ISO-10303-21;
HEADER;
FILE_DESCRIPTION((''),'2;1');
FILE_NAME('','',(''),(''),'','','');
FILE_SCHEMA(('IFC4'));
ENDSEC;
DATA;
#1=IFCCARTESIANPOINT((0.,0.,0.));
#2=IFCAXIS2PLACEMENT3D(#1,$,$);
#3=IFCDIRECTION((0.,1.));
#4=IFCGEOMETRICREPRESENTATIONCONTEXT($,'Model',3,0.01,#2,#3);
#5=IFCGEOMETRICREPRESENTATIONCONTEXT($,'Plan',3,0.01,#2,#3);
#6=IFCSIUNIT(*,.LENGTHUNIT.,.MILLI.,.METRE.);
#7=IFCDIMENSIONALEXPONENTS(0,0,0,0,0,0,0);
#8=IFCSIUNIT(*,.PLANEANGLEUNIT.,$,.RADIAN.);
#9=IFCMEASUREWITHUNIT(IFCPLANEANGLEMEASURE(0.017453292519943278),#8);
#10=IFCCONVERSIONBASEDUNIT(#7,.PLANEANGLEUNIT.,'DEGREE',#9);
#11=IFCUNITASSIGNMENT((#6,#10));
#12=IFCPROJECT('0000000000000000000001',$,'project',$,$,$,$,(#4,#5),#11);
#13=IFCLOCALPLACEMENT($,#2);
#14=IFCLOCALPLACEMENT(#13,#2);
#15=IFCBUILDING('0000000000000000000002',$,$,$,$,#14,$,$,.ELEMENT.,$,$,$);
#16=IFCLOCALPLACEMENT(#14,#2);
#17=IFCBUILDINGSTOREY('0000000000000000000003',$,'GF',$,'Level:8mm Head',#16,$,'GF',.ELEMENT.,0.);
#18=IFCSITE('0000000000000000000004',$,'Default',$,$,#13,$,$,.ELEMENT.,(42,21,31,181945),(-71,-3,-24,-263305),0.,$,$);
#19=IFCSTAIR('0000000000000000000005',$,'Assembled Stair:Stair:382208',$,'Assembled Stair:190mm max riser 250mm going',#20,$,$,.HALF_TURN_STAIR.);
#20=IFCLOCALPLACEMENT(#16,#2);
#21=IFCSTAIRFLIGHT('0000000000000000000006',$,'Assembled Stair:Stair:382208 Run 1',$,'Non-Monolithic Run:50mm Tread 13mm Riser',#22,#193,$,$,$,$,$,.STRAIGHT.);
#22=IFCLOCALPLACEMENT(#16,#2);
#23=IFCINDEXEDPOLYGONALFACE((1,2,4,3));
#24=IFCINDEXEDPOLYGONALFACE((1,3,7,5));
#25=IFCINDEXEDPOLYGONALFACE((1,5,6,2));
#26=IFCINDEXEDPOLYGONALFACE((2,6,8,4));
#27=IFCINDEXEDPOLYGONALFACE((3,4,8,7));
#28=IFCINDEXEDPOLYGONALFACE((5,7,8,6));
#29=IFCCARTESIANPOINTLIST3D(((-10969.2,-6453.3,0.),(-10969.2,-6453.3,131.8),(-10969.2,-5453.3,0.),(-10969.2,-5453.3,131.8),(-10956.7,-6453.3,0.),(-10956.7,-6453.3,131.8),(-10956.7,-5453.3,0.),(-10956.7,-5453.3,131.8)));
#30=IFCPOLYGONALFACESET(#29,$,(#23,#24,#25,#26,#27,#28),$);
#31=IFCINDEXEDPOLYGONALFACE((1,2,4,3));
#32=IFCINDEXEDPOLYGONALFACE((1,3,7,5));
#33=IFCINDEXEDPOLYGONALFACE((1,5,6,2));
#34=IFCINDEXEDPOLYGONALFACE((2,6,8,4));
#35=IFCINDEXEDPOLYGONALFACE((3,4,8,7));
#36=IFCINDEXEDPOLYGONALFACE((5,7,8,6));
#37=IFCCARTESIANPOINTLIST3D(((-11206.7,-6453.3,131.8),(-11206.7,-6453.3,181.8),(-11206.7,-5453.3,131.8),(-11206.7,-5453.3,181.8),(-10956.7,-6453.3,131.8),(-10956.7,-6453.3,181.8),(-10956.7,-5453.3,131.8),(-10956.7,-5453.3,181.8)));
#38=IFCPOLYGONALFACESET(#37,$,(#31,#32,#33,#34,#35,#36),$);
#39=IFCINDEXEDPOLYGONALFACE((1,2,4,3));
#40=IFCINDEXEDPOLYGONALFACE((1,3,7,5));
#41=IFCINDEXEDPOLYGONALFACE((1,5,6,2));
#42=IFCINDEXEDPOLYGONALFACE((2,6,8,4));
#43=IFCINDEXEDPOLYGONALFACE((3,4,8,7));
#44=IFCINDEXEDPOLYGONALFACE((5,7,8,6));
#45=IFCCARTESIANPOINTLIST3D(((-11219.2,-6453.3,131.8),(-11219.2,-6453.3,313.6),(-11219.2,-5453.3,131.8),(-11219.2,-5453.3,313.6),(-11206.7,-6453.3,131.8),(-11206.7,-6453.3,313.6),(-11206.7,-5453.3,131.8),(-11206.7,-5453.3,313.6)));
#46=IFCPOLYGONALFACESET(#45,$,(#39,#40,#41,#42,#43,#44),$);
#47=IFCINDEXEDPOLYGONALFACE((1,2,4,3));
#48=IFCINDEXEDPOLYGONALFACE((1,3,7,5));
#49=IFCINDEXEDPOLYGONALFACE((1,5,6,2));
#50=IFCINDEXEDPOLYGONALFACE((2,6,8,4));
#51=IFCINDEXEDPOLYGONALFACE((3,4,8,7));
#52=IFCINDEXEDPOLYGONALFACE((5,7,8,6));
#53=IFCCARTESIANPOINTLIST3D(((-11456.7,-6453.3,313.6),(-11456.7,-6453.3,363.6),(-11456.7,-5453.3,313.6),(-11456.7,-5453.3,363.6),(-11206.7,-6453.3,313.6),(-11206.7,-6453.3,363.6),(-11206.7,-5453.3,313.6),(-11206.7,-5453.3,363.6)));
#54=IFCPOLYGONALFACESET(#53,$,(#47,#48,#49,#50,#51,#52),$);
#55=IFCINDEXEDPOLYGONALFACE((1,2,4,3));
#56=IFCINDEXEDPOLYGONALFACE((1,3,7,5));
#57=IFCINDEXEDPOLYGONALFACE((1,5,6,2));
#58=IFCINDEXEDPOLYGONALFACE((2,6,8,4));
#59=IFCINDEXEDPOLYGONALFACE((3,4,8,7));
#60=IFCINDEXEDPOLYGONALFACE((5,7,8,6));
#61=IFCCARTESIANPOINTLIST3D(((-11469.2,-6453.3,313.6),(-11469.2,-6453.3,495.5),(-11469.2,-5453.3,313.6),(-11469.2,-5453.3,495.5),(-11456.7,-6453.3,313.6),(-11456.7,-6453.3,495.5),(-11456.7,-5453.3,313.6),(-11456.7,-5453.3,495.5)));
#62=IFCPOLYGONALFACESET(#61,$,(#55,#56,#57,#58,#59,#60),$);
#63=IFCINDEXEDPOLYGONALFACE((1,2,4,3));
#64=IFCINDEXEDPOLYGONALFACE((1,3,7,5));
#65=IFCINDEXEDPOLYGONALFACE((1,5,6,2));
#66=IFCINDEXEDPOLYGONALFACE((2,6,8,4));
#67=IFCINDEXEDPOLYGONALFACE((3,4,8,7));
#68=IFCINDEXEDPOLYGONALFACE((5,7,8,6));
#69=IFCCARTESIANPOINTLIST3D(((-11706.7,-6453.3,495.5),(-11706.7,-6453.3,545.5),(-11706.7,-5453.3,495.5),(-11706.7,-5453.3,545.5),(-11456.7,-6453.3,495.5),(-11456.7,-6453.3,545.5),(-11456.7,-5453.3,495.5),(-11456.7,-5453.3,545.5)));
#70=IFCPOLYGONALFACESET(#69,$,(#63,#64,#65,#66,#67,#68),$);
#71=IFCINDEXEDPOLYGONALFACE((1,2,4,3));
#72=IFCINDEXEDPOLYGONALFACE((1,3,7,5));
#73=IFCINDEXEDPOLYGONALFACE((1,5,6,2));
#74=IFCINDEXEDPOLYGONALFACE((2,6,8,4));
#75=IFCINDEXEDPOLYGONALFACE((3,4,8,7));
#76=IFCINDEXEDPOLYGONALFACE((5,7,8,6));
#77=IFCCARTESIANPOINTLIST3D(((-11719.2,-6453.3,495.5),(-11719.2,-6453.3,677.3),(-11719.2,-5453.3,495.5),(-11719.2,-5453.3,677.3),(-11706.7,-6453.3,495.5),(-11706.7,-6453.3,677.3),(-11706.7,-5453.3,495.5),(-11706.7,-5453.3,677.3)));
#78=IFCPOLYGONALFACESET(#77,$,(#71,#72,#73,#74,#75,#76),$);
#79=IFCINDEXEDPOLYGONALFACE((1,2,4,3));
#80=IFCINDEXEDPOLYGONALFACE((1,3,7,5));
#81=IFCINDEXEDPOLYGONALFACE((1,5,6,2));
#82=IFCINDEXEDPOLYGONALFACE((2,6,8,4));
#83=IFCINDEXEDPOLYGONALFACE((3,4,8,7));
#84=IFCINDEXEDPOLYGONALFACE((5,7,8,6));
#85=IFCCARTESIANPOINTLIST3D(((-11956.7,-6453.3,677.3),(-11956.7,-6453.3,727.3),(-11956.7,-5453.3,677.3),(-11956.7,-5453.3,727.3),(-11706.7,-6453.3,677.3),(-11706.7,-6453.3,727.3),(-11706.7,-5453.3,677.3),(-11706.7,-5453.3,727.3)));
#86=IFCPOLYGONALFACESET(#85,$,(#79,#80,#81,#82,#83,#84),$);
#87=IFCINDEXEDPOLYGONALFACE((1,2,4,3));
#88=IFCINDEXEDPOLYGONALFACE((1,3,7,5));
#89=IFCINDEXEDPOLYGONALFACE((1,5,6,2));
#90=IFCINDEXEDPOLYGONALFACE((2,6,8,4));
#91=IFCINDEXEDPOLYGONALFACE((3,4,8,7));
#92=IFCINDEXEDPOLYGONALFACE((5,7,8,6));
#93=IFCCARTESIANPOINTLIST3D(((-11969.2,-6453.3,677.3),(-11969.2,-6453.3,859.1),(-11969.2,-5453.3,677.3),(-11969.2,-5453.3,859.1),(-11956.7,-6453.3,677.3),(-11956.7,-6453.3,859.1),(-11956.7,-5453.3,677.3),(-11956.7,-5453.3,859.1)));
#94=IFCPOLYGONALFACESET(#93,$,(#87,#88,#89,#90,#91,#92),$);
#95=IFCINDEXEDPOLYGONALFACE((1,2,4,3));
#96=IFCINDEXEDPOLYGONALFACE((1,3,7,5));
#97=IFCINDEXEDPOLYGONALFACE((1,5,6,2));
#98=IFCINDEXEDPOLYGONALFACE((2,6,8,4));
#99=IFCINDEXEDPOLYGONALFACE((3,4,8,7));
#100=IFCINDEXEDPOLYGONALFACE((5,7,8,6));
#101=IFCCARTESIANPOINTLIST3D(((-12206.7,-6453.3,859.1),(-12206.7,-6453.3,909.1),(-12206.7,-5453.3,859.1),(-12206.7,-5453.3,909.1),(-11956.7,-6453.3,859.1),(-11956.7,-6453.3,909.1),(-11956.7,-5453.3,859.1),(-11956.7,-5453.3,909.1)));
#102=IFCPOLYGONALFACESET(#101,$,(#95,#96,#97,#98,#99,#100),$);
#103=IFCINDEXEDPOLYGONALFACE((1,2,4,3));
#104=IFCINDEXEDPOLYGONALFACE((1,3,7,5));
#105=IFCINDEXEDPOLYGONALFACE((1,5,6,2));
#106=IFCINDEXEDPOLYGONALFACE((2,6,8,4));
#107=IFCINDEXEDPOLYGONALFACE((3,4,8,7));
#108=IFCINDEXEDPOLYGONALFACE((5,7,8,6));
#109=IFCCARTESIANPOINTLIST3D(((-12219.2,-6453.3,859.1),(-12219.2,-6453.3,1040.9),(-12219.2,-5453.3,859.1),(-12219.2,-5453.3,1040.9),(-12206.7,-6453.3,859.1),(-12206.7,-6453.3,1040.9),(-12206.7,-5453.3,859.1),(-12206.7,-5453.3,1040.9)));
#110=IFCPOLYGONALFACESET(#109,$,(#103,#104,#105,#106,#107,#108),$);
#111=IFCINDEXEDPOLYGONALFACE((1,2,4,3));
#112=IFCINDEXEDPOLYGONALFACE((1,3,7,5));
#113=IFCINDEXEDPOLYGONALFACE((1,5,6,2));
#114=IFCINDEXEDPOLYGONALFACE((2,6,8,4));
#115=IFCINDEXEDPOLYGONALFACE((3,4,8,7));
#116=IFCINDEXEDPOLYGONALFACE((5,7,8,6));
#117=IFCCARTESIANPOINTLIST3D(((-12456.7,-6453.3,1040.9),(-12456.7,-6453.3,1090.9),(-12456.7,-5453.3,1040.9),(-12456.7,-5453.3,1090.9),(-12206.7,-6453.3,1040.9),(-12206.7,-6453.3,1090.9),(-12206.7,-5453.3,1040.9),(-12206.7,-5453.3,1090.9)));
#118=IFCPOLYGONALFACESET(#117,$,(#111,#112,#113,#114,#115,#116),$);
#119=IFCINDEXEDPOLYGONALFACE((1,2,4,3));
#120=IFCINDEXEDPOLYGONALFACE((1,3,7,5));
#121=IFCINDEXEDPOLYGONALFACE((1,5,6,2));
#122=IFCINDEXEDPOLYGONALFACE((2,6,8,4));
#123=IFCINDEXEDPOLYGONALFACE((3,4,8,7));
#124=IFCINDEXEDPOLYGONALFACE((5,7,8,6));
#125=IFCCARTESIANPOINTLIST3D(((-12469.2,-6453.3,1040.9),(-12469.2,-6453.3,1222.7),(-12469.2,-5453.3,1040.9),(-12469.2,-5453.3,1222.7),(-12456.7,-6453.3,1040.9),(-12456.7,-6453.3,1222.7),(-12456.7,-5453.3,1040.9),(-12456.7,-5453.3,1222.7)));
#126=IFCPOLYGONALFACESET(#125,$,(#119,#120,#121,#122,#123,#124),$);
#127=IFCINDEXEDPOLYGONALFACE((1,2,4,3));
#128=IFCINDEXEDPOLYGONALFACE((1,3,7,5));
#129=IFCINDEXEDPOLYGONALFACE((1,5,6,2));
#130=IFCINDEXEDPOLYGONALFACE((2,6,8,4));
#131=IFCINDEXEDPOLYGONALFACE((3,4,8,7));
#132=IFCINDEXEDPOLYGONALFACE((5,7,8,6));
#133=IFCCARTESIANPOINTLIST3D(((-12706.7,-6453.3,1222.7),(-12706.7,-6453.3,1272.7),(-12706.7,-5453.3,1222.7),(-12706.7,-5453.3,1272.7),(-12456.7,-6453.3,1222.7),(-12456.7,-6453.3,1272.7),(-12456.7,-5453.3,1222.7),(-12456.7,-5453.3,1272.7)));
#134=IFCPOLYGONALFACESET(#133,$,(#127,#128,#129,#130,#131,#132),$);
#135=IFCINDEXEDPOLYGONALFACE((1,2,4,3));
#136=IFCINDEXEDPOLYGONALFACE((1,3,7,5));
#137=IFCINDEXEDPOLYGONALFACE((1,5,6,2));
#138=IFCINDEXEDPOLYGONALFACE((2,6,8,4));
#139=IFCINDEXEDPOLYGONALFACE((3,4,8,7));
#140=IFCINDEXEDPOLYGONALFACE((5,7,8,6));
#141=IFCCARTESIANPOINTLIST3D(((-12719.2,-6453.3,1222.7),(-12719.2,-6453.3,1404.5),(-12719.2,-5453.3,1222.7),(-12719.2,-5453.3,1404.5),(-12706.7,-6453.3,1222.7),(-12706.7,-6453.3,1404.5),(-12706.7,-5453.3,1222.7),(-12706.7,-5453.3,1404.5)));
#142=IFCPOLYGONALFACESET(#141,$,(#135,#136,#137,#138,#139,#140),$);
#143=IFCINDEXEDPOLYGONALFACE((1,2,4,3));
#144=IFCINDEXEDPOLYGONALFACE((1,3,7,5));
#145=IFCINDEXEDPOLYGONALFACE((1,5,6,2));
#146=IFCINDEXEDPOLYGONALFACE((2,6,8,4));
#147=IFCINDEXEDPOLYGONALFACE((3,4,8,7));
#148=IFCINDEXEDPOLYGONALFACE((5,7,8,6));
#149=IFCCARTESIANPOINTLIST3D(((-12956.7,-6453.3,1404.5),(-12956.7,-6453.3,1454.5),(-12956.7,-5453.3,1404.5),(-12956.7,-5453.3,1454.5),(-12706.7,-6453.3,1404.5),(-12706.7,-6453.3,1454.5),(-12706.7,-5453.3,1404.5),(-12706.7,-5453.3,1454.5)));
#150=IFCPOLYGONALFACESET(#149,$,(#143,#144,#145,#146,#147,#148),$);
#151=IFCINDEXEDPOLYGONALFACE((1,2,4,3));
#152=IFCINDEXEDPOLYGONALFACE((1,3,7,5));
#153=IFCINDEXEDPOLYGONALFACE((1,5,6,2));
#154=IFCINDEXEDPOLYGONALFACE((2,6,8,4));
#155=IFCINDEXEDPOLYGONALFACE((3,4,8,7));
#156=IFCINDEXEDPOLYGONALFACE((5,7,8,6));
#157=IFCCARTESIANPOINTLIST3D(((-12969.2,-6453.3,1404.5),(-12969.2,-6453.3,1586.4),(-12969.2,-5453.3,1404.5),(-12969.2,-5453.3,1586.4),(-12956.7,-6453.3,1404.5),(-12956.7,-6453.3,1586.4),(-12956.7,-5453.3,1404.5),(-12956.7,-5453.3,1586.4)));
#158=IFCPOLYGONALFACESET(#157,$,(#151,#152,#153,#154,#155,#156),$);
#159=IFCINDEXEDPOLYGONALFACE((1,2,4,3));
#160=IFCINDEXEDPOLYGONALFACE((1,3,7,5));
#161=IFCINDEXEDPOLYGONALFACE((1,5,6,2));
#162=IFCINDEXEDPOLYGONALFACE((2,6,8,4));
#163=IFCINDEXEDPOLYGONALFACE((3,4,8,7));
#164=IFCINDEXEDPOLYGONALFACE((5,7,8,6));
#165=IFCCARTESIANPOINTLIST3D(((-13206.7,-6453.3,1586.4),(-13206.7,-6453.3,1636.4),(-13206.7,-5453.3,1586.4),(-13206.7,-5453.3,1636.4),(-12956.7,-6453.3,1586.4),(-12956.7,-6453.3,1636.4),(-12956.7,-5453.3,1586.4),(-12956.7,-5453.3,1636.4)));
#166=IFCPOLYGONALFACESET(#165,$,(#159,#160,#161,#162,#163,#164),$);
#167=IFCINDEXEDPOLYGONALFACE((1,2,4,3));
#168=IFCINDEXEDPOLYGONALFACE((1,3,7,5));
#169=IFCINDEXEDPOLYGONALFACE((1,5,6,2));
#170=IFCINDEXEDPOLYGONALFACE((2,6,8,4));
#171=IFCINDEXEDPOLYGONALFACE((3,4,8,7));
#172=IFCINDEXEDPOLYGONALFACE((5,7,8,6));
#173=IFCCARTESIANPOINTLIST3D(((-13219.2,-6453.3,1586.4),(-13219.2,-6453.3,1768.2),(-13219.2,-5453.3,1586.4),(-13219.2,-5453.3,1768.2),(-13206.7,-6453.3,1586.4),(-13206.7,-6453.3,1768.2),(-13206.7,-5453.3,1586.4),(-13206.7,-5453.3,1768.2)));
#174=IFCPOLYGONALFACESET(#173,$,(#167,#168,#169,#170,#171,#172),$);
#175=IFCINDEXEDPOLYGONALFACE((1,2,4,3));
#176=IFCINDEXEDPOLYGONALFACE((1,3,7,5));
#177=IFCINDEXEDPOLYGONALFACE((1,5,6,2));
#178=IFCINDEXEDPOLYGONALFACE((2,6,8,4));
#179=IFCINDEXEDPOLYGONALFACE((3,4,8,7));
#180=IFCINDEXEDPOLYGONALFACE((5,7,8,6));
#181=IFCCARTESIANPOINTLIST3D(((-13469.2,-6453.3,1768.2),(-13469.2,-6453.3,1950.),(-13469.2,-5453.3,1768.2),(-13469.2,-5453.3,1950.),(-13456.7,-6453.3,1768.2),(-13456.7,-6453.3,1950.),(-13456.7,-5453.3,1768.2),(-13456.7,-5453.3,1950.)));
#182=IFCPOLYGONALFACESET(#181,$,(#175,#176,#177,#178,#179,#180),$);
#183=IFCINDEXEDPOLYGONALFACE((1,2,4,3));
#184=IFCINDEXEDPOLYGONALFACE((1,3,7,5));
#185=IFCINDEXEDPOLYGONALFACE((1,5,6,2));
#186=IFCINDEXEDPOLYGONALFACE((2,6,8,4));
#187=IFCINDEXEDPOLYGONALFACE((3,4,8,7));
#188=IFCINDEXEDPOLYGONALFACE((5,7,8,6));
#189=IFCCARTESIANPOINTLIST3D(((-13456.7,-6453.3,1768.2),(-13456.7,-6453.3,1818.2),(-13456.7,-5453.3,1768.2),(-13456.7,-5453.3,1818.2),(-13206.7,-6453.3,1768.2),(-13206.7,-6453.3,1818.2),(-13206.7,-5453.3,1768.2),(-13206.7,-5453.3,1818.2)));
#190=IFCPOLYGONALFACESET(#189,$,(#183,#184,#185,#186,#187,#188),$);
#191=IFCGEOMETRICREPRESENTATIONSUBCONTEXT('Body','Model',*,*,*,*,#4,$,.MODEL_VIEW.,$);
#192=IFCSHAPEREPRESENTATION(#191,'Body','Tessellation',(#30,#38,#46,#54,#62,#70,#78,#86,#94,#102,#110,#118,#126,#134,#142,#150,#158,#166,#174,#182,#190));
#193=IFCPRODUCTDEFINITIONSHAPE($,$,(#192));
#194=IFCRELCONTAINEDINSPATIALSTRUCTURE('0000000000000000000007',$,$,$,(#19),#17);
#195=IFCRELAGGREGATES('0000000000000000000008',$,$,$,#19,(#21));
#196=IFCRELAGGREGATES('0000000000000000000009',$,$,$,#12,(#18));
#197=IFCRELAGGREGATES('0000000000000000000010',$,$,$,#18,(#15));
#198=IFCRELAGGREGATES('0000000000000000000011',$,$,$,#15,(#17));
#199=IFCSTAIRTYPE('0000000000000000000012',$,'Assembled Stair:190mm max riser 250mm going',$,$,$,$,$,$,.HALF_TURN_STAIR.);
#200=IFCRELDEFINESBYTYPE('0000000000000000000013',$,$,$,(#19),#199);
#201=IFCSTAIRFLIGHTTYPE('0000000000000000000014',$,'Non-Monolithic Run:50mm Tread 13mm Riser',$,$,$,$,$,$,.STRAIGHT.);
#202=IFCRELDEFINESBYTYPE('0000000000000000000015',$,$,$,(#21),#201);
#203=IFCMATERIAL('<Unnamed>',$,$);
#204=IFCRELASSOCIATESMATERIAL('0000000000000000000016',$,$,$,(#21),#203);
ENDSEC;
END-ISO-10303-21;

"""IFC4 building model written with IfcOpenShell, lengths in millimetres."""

from ifc_helpers import new_model, entity, si_unit, converted_unit, direction, frame, origin, place, context, subcontext, project, spatial, indexed_curve, outline, extrude, material, type_object, element, aggregate, save


model = new_model("IFC4")

# Units and contexts
model_context = context("Model", 3, precision=0.01, world=origin(), true_north=direction((0.0, 1.0)))
plan_context = context("Plan", 3, precision=0.01, world=origin(), true_north=direction((0.0, 1.0)))
body_context = subcontext(model_context, "Body", "Model", "MODEL_VIEW")
ifc_project = project(units=[si_unit("LENGTHUNIT", "METRE", prefix="MILLI"), converted_unit("PLANEANGLEUNIT", "DEGREE", entity("IfcPlaneAngleMeasure", 0.017453292519943278), si_unit("PLANEANGLEUNIT", "RADIAN"), dimensions=[0, 0, 0, 0, 0, 0, 0])], contexts=[model_context, plan_context])

# Site, building, storey
site_placement = place(None, origin())
site = spatial("IfcSite", under=ifc_project, at=site_placement, Name="Default", CompositionType="ELEMENT", RefLatitude=(42, 21, 31, 181945), RefLongitude=(-71, -3, -24, -263305), RefElevation=0.0)
building_placement = place(site_placement, origin())
building = spatial("IfcBuilding", under=site, at=building_placement, CompositionType="ELEMENT")
storey_placement = place(building_placement, origin())
storey = spatial("IfcBuildingStorey", under=building, at=storey_placement, Name="GF", ObjectType="Level:8mm Head", LongName="GF", CompositionType="ELEMENT", Elevation=0.0)

# Stair
stair_type = type_object("IfcStairType", Name="Assembled Stair:190mm max riser 250mm going", PredefinedType="HALF_TURN_STAIR")
stair_placement = place(storey_placement, origin())
stair = element("IfcStair", 1, at=stair_placement, inside=storey, type_object=stair_type, Name="Assembled Stair:Stair:382208", ObjectType="Assembled Stair:190mm max riser 250mm going", PredefinedType="HALF_TURN_STAIR")
ifc_material_1 = material(Name="<Unnamed>")

# Stair flight
stair_flight_type = type_object("IfcStairFlightType", Name="Non-Monolithic Run:50mm Tread 13mm Riser", PredefinedType="STRAIGHT")
stair_flight_1_placement = place(stair_placement, origin())
stair_flight_1 = element("IfcStairFlight", 2, at=stair_flight_1_placement, type_object=stair_flight_type, material=ifc_material_1, Name="Assembled Stair:Stair:382208 Run 1", ObjectType="Non-Monolithic Run:50mm Tread 13mm Riser", PredefinedType="STRAIGHT", context=body_context, shape_type="SweptSolid", body=[
    extrude(outline(indexed_curve([(-500.0, -6.3), (500.0, -6.3), (500.0, 6.2), (-500.0, 6.2), (-500.0, -6.3)], self_intersect=False)), frame((-10962.9, -5953.3, 0.0), z_axis=(0.0, 0.0, 1.0), x_axis=(0.0, -1.0, 0.0)), (0.0, 0.0, 1.0), 131.8),
    extrude(outline(indexed_curve([(-125.0, -500.0), (125.0, -500.0), (125.0, 500.0), (-125.0, 500.0), (-125.0, -500.0)], self_intersect=False)), frame((-11081.7, -5953.3, 131.8)), (0.0, 0.0, 1.0), 50.0),
    extrude(outline(indexed_curve([(-500.0, -6.2), (500.0, -6.2), (500.0, 6.3), (-500.0, 6.3), (-500.0, -6.2)], self_intersect=False)), frame((-11212.9, -5953.3, 131.8), z_axis=(0.0, 0.0, 1.0), x_axis=(0.0, -1.0, 0.0)), (0.0, 0.0, 1.0), 181.8),
    extrude(outline(indexed_curve([(-125.0, -500.0), (125.0, -500.0), (125.0, 500.0), (-125.0, 500.0), (-125.0, -500.0)], self_intersect=False)), frame((-11331.7, -5953.3, 313.6)), (0.0, 0.0, 1.0), 50.0),
    extrude(outline(indexed_curve([(-500.0, -6.2), (500.0, -6.2), (500.0, 6.3), (-500.0, 6.3), (-500.0, -6.2)], self_intersect=False)), frame((-11462.9, -5953.3, 313.6), z_axis=(0.0, 0.0, 1.0), x_axis=(0.0, -1.0, 0.0)), (0.0, 0.0, 1.0), 181.8),
    extrude(outline(indexed_curve([(-125.0, -500.0), (125.0, -500.0), (125.0, 500.0), (-125.0, 500.0), (-125.0, -500.0)], self_intersect=False)), frame((-11581.7, -5953.3, 495.5)), (0.0, 0.0, 1.0), 50.0),
    extrude(outline(indexed_curve([(-500.0, -6.2), (500.0, -6.2), (500.0, 6.3), (-500.0, 6.3), (-500.0, -6.2)], self_intersect=False)), frame((-11712.9, -5953.3, 495.5), z_axis=(0.0, 0.0, 1.0), x_axis=(0.0, -1.0, 0.0)), (0.0, 0.0, 1.0), 181.8),
    extrude(outline(indexed_curve([(-125.0, -500.0), (125.0, -500.0), (125.0, 500.0), (-125.0, 500.0), (-125.0, -500.0)], self_intersect=False)), frame((-11831.7, -5953.3, 677.3)), (0.0, 0.0, 1.0), 50.0),
    extrude(outline(indexed_curve([(-500.0, -6.2), (500.0, -6.2), (500.0, 6.3), (-500.0, 6.3), (-500.0, -6.2)], self_intersect=False)), frame((-11962.9, -5953.3, 677.3), z_axis=(0.0, 0.0, 1.0), x_axis=(0.0, -1.0, 0.0)), (0.0, 0.0, 1.0), 181.8),
    extrude(outline(indexed_curve([(-125.0, -500.0), (125.0, -500.0), (125.0, 500.0), (-125.0, 500.0), (-125.0, -500.0)], self_intersect=False)), frame((-12081.7, -5953.3, 859.1)), (0.0, 0.0, 1.0), 50.0),
    extrude(outline(indexed_curve([(-500.0, -6.2), (500.0, -6.2), (500.0, 6.3), (-500.0, 6.3), (-500.0, -6.2)], self_intersect=False)), frame((-12212.9, -5953.3, 859.1), z_axis=(0.0, 0.0, 1.0), x_axis=(0.0, -1.0, 0.0)), (0.0, 0.0, 1.0), 181.8),
    extrude(outline(indexed_curve([(-125.0, -500.0), (125.0, -500.0), (125.0, 500.0), (-125.0, 500.0), (-125.0, -500.0)], self_intersect=False)), frame((-12331.7, -5953.3, 1040.9)), (0.0, 0.0, 1.0), 50.0),
    extrude(outline(indexed_curve([(-500.0, -6.2), (500.0, -6.2), (500.0, 6.3), (-500.0, 6.3), (-500.0, -6.2)], self_intersect=False)), frame((-12462.9, -5953.3, 1040.9), z_axis=(0.0, 0.0, 1.0), x_axis=(0.0, -1.0, 0.0)), (0.0, 0.0, 1.0), 181.8),
    extrude(outline(indexed_curve([(-125.0, -500.0), (125.0, -500.0), (125.0, 500.0), (-125.0, 500.0), (-125.0, -500.0)], self_intersect=False)), frame((-12581.7, -5953.3, 1222.7)), (0.0, 0.0, 1.0), 50.0),
    extrude(outline(indexed_curve([(-500.0, -6.3), (500.0, -6.3), (500.0, 6.2), (-500.0, 6.2), (-500.0, -6.3)], self_intersect=False)), frame((-12712.9, -5953.3, 1222.7), z_axis=(0.0, 0.0, 1.0), x_axis=(0.0, -1.0, 0.0)), (0.0, 0.0, 1.0), 181.8),
    extrude(outline(indexed_curve([(-125.0, -500.0), (125.0, -500.0), (125.0, 500.0), (-125.0, 500.0), (-125.0, -500.0)], self_intersect=False)), frame((-12831.7, -5953.3, 1404.5)), (0.0, 0.0, 1.0), 50.0),
    extrude(outline(indexed_curve([(-500.0, -6.2), (500.0, -6.2), (500.0, 6.3), (-500.0, 6.3), (-500.0, -6.2)], self_intersect=False)), frame((-12962.9, -5953.3, 1404.5), z_axis=(0.0, 0.0, 1.0), x_axis=(0.0, -1.0, 0.0)), (0.0, 0.0, 1.0), 181.8),
    extrude(outline(indexed_curve([(-125.0, -500.0), (125.0, -500.0), (125.0, 500.0), (-125.0, 500.0), (-125.0, -500.0)], self_intersect=False)), frame((-13081.7, -5953.3, 1586.4)), (0.0, 0.0, 1.0), 50.0),
    extrude(outline(indexed_curve([(-500.0, -6.3), (500.0, -6.3), (500.0, 6.2), (-500.0, 6.2), (-500.0, -6.3)], self_intersect=False)), frame((-13212.9, -5953.3, 1586.4), z_axis=(0.0, 0.0, 1.0), x_axis=(0.0, -1.0, 0.0)), (0.0, 0.0, 1.0), 181.8),
    extrude(outline(indexed_curve([(-500.0, -6.2), (500.0, -6.2), (500.0, 6.3), (-500.0, 6.3), (-500.0, -6.2)], self_intersect=False)), frame((-13462.9, -5953.3, 1768.2), z_axis=(0.0, 0.0, 1.0), x_axis=(0.0, -1.0, 0.0)), (0.0, 0.0, 1.0), 181.8),
    extrude(outline(indexed_curve([(-125.0, -500.0), (125.0, -500.0), (125.0, 500.0), (-125.0, 500.0), (-125.0, -500.0)], self_intersect=False)), frame((-13331.7, -5953.3, 1768.2)), (0.0, 0.0, 1.0), 50.0),
])
aggregate(stair, [stair_flight_1])

save(model, "model.ifc")
